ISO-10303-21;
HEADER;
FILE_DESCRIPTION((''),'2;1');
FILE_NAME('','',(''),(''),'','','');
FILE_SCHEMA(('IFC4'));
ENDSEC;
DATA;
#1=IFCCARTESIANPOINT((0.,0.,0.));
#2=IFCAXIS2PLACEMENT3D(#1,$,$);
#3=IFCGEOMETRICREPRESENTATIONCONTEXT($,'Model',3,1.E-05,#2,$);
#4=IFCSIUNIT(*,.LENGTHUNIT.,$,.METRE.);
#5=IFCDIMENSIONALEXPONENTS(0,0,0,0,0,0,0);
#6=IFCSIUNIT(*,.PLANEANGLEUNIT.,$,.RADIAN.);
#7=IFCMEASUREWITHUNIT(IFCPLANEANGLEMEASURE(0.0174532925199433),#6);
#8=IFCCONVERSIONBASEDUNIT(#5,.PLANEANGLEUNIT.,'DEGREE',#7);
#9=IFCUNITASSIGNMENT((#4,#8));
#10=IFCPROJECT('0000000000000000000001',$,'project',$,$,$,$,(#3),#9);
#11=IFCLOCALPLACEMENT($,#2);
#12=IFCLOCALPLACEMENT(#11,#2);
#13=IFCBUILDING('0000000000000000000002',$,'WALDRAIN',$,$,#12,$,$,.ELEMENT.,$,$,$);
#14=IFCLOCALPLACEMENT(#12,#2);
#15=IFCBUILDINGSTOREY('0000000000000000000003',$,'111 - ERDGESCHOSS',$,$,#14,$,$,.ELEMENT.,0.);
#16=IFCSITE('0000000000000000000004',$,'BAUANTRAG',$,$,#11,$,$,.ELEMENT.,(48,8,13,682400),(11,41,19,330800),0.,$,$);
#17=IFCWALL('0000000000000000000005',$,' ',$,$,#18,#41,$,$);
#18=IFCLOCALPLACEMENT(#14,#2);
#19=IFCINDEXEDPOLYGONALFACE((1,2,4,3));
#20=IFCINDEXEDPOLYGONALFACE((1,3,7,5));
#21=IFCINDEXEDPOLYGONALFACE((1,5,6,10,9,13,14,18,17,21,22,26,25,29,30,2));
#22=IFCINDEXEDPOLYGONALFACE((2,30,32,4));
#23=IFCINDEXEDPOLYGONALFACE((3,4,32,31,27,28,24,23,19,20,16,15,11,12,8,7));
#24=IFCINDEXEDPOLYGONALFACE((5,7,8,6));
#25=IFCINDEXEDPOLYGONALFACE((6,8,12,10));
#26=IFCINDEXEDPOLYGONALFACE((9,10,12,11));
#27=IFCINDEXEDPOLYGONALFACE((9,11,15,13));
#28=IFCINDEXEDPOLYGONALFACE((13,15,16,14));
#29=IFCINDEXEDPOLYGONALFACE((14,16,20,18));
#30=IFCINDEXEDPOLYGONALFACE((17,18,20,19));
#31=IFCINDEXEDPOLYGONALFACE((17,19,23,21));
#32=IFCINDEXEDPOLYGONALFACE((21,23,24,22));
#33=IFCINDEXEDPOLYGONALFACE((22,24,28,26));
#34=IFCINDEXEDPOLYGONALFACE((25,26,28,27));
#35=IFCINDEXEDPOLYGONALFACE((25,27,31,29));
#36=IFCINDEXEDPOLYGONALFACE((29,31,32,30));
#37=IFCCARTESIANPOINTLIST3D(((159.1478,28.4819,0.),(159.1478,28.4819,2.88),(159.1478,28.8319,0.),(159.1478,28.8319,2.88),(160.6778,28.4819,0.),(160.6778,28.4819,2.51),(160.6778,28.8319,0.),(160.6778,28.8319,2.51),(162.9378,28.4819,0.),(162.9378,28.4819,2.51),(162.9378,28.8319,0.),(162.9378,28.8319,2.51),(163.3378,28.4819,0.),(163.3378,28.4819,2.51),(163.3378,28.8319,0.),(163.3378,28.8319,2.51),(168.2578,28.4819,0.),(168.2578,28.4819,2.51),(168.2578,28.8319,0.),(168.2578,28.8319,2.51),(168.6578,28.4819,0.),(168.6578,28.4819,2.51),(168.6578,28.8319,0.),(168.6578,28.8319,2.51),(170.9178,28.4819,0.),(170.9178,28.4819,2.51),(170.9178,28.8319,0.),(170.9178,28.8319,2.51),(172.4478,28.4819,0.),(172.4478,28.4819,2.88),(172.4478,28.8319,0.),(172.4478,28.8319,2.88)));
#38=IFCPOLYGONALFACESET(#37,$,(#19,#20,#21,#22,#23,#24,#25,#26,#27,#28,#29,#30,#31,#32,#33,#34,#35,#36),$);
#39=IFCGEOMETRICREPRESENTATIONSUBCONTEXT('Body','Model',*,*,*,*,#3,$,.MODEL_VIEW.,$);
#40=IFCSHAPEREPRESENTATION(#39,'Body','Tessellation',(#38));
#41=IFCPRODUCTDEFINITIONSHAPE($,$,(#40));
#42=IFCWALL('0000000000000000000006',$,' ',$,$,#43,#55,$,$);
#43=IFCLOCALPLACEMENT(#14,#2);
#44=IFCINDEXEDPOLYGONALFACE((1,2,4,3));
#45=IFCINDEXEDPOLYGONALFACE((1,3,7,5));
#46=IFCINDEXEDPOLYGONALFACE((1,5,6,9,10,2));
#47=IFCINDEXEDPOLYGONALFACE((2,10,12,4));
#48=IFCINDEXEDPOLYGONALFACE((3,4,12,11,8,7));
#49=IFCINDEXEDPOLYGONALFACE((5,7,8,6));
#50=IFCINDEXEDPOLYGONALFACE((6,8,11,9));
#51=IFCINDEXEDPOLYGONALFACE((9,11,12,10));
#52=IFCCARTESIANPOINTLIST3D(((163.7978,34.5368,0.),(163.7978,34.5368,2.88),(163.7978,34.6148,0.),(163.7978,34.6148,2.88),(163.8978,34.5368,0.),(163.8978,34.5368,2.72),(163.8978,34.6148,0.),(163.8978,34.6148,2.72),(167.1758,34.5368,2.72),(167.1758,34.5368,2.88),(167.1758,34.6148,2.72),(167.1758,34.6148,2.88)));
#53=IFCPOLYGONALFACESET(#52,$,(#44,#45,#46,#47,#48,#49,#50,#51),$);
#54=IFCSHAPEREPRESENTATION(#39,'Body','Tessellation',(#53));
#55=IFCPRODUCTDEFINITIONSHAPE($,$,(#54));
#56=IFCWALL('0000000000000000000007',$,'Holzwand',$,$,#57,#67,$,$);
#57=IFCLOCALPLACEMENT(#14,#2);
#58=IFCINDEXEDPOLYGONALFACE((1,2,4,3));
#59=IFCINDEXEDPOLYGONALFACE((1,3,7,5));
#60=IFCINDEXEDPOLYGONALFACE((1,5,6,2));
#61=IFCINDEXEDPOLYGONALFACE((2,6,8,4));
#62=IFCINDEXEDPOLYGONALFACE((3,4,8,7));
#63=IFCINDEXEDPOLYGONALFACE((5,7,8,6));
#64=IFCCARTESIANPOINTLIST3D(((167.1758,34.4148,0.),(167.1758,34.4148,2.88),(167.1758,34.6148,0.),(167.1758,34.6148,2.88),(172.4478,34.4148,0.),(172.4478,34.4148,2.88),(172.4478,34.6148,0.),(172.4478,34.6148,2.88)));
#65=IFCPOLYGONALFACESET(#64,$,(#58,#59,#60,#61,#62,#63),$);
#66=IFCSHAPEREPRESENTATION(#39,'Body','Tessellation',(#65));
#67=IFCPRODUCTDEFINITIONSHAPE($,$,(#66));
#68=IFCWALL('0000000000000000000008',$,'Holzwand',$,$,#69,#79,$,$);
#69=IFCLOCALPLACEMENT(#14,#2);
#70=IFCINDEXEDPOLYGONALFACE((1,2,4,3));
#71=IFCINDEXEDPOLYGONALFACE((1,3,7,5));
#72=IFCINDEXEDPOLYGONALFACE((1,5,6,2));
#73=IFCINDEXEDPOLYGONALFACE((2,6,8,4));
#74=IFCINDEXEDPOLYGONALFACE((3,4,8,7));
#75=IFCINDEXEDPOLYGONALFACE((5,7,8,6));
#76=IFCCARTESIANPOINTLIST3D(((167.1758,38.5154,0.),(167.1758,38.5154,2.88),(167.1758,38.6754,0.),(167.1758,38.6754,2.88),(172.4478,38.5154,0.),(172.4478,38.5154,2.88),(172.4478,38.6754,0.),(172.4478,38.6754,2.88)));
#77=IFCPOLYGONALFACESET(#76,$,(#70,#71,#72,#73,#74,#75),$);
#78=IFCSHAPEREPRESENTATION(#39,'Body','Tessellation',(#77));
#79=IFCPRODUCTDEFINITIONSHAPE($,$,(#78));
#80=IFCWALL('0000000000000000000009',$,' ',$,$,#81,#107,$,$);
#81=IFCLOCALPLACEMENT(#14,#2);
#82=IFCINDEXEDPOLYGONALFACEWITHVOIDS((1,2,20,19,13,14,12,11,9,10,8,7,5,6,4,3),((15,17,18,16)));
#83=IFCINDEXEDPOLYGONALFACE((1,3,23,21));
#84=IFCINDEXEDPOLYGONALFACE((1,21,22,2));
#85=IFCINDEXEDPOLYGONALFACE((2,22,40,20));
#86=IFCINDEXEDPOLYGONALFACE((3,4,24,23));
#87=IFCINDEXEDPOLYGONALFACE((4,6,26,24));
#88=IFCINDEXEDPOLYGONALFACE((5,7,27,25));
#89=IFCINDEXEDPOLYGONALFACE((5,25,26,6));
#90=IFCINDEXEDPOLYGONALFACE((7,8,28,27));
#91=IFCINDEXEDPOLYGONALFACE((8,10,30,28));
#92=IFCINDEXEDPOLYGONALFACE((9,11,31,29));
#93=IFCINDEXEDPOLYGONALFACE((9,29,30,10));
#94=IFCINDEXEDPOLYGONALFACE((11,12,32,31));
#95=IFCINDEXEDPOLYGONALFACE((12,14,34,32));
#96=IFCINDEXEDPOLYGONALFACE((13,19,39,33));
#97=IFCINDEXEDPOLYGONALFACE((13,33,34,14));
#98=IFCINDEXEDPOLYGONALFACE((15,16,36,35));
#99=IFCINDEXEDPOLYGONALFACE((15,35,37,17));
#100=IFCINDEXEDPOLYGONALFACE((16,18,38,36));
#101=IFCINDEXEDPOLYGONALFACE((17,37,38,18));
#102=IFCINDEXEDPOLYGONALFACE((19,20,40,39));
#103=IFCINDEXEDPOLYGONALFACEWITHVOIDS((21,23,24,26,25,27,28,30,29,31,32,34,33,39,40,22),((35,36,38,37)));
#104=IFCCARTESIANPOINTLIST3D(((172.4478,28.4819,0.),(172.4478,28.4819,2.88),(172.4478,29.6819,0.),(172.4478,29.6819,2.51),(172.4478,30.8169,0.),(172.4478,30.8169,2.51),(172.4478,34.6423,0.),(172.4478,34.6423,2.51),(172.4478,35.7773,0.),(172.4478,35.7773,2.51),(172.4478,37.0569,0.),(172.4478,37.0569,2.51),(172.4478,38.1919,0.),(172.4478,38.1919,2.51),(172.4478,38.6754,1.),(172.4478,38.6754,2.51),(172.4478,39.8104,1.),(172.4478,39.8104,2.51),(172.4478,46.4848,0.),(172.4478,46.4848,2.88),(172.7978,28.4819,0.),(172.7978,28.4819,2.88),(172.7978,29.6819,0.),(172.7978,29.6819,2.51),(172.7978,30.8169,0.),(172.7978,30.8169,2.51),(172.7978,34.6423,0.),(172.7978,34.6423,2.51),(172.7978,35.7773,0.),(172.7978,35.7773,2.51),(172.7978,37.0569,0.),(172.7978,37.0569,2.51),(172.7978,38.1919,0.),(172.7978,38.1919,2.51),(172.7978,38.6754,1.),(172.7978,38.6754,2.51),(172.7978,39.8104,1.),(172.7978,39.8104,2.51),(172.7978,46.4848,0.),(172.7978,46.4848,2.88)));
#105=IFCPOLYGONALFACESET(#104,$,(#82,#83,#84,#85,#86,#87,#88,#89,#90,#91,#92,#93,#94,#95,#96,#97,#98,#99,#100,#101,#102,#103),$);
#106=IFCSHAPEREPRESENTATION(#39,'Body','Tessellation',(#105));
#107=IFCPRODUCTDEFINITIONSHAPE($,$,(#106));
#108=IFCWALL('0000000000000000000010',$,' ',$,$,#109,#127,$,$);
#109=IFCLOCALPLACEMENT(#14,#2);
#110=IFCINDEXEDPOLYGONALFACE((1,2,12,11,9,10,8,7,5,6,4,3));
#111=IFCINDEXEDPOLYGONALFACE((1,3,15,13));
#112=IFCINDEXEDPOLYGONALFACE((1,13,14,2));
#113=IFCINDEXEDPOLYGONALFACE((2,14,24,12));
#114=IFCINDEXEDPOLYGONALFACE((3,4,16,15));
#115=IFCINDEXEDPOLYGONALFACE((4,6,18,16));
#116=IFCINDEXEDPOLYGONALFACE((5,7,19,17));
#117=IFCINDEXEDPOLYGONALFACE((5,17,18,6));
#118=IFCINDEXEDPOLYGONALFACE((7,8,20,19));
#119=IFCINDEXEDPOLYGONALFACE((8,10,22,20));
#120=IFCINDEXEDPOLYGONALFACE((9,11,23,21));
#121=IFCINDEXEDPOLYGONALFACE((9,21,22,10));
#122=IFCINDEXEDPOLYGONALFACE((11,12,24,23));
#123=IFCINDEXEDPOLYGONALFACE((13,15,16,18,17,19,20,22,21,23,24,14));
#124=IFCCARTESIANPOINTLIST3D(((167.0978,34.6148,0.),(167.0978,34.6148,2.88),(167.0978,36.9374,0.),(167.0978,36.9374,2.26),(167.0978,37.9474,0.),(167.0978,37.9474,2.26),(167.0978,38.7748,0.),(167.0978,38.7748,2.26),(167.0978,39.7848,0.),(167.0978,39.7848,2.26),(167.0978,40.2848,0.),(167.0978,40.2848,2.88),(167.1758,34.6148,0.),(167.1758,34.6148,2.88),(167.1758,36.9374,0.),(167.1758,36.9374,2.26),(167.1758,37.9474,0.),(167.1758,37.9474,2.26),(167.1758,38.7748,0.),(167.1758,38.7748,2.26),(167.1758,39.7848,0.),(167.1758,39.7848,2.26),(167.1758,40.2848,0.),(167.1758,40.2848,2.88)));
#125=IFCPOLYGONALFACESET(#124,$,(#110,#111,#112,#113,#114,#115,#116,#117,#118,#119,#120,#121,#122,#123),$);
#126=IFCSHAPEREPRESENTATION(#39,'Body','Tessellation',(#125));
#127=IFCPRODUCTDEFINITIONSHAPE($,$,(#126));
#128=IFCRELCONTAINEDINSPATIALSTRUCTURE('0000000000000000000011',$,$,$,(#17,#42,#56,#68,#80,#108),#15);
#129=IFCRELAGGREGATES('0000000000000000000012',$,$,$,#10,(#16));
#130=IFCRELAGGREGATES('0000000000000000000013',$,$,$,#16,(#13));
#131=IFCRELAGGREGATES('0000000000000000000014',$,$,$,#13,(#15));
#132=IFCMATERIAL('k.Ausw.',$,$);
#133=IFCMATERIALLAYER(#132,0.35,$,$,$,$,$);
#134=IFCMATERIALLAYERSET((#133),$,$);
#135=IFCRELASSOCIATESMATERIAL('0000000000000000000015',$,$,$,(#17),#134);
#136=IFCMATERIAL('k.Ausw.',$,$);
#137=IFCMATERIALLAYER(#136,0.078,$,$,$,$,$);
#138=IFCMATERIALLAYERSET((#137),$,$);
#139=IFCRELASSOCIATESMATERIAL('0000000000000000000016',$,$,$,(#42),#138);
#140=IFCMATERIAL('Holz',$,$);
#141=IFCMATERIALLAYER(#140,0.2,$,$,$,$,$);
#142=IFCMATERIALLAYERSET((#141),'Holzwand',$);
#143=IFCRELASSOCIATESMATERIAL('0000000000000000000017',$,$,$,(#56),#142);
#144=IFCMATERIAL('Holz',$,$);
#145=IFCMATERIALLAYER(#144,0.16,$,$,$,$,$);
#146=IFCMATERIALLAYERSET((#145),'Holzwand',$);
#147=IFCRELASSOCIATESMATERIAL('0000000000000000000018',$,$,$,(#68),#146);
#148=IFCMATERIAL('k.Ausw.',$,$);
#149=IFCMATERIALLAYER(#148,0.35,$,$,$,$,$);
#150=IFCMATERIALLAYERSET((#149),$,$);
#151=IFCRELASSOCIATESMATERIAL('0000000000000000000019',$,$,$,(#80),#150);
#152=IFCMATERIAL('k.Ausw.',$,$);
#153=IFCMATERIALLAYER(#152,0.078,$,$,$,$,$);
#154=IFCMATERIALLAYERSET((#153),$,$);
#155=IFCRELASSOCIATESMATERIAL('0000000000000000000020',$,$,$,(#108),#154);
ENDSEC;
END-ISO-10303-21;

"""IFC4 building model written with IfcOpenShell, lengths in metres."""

from ifc_helpers import new_model, entity, si_unit, converted_unit, frame, frame_2d, origin, origin_with_axes, place, context, subcontext, project, spatial, polyline, rectangle, outline, extrude, material, layer, layer_set, layer_usage, element, save


model = new_model("IFC4")

# Units and contexts
model_context = context("Model", 3, precision=1e-05, world=origin())
body_context = subcontext(model_context, "Body", "Model", "MODEL_VIEW")
ifc_project = project(units=[si_unit("LENGTHUNIT", "METRE"), converted_unit("PLANEANGLEUNIT", "DEGREE", entity("IfcPlaneAngleMeasure", 0.0174532925199433), si_unit("PLANEANGLEUNIT", "RADIAN"), dimensions=[0, 0, 0, 0, 0, 0, 0])], contexts=[model_context])

# Site, building, storey
site_placement = place(None, origin())
site = spatial("IfcSite", under=ifc_project, at=site_placement, Name="BAUANTRAG", CompositionType="ELEMENT", RefLatitude=(48, 8, 13, 682400), RefLongitude=(11, 41, 19, 330800), RefElevation=0.0)
building_placement = place(site_placement, origin())
building = spatial("IfcBuilding", under=site, at=building_placement, Name="WALDRAIN", CompositionType="ELEMENT")
storey_placement = place(building_placement, origin())
storey = spatial("IfcBuildingStorey", under=building, at=storey_placement, Name="111 - ERDGESCHOSS", CompositionType="ELEMENT", Elevation=0.0)

# Wall, openings
ifc_material_1 = material(Name="k.Ausw.")
ifc_layer_1 = layer(ifc_material_1, 0.35)
ifc_layer_set_1 = layer_set([ifc_layer_1])
ifc_layer_usage_1 = layer_usage(ifc_layer_set_1, "AXIS2", "POSITIVE", 0.0)
wall_1_placement = place(storey_placement, frame((159.1478, 28.4819, 0.0)))
wall_1 = element("IfcWall", 1, at=wall_1_placement, inside=storey, material=ifc_layer_usage_1, Name=" ", context=body_context, shape_type="SweptSolid", body=[
    extrude(rectangle(XDim=13.3, YDim=0.35, at=frame_2d((6.65, 0.175), x_axis=(1.0, 0.0))), origin_with_axes(), (0.0, 0.0, 1.0), 2.88),
])
opening_1_placement = place(wall_1_placement, frame((1.53, 0.0, 0.0), z_axis=(0.0, 1.0, 0.0), x_axis=(0.0, 0.0, 1.0)))
element("IfcOpeningElement", 2, at=opening_1_placement, cuts=wall_1, ObjectType="Opening", context=body_context, shape_type="SweptSolid", body=[
    extrude(outline(polyline([(0.0, 2.26), (2.51, 2.26), (2.51, 0.0), (0.0, 0.0), (0.0, 2.26)])), origin_with_axes(), (0.0, 0.0, 1.0), 0.35),
])
opening_2_placement = place(wall_1_placement, frame((4.19, 0.0, 0.0), z_axis=(0.0, 1.0, 0.0), x_axis=(0.0, 0.0, 1.0)))
element("IfcOpeningElement", 3, at=opening_2_placement, cuts=wall_1, ObjectType="Opening", context=body_context, shape_type="SweptSolid", body=[
    extrude(outline(polyline([(0.0, 4.92), (2.51, 4.92), (2.51, 0.0), (0.0, 0.0), (0.0, 4.92)])), origin_with_axes(), (0.0, 0.0, 1.0), 0.35),
])
opening_3_placement = place(wall_1_placement, frame((9.51, 0.0, 0.0), z_axis=(0.0, 1.0, 0.0), x_axis=(0.0, 0.0, 1.0)))
element("IfcOpeningElement", 4, at=opening_3_placement, cuts=wall_1, ObjectType="Opening", context=body_context, shape_type="SweptSolid", body=[
    extrude(outline(polyline([(0.0, 2.26), (2.51, 2.26), (2.51, 0.0), (0.0, 0.0), (0.0, 2.26)])), origin_with_axes(), (0.0, 0.0, 1.0), 0.35),
])

# Wall, opening
ifc_material_2 = material(Name="k.Ausw.")
ifc_layer_2 = layer(ifc_material_2, 0.078)
ifc_layer_set_2 = layer_set([ifc_layer_2])
ifc_layer_usage_2 = layer_usage(ifc_layer_set_2, "AXIS2", "POSITIVE", 0.0)
wall_2_placement = place(storey_placement, frame((163.7978, 34.5368, 0.0)))
wall_2 = element("IfcWall", 5, at=wall_2_placement, inside=storey, material=ifc_layer_usage_2, Name=" ", context=body_context, shape_type="SweptSolid", body=[
    extrude(rectangle(XDim=3.378, YDim=0.078, at=frame_2d((1.689, 0.039), x_axis=(1.0, 0.0))), origin_with_axes(), (0.0, 0.0, 1.0), 2.88),
])
opening_4_placement = place(wall_2_placement, frame((0.1, 0.0, 0.0), z_axis=(0.0, 1.0, 0.0), x_axis=(0.0, 0.0, 1.0)))
element("IfcOpeningElement", 6, at=opening_4_placement, cuts=wall_2, ObjectType="Opening", context=body_context, shape_type="SweptSolid", body=[
    extrude(outline(polyline([(0.0, 3.278), (2.72, 3.278), (2.72, 0.0), (0.0, 0.0), (0.0, 3.278)])), origin_with_axes(), (0.0, 0.0, 1.0), 0.078),
])

# Walls
ifc_material_3 = material(Name="Holz")
ifc_layer_3 = layer(ifc_material_3, 0.2)
ifc_layer_set_3 = layer_set([ifc_layer_3], Name="Holzwand")
ifc_layer_usage_3 = layer_usage(ifc_layer_set_3, "AXIS2", "POSITIVE", 0.0)
wall_3_placement = place(storey_placement, frame((167.1758, 34.4148, 0.0)))
element("IfcWall", 7, at=wall_3_placement, inside=storey, material=ifc_layer_usage_3, Name="Holzwand", context=body_context, shape_type="SweptSolid", body=[
    extrude(rectangle(XDim=5.272, YDim=0.2, at=frame_2d((2.636, 0.1), x_axis=(1.0, 0.0))), origin_with_axes(), (0.0, 0.0, 1.0), 2.88),
])
ifc_material_4 = material(Name="Holz")
ifc_layer_4 = layer(ifc_material_4, 0.16)
ifc_layer_set_4 = layer_set([ifc_layer_4], Name="Holzwand")
ifc_layer_usage_4 = layer_usage(ifc_layer_set_4, "AXIS2", "POSITIVE", 0.0)
wall_4_placement = place(storey_placement, frame((172.4478, 38.6754, 0.0), z_axis=(0.0, 0.0, 1.0), x_axis=(-1.0, 0.0, 0.0)))
element("IfcWall", 8, at=wall_4_placement, inside=storey, material=ifc_layer_usage_4, Name="Holzwand", context=body_context, shape_type="SweptSolid", body=[
    extrude(rectangle(XDim=5.272, YDim=0.16, at=frame_2d((2.636, 0.08), x_axis=(1.0, 0.0))), origin_with_axes(), (0.0, 0.0, 1.0), 2.88),
])

# Walls, openings
ifc_material_5 = material(Name="k.Ausw.")
ifc_layer_5 = layer(ifc_material_5, 0.35)
ifc_layer_set_5 = layer_set([ifc_layer_5])
ifc_layer_usage_5 = layer_usage(ifc_layer_set_5, "AXIS2", "POSITIVE", 0.0)
wall_5_placement = place(storey_placement, frame((172.7978, 28.4819, 0.0), z_axis=(0.0, 0.0, 1.0), x_axis=(0.0, 1.0, 0.0)))
wall_5 = element("IfcWall", 9, at=wall_5_placement, inside=storey, material=ifc_layer_usage_5, Name=" ", context=body_context, shape_type="SweptSolid", body=[
    extrude(rectangle(XDim=18.0029, YDim=0.35, at=frame_2d((9.0014, 0.175), x_axis=(1.0, 0.0))), origin_with_axes(), (0.0, 0.0, 1.0), 2.88),
])
opening_5_placement = place(wall_5_placement, frame((1.2, 0.0, 0.0), z_axis=(0.0, 1.0, 0.0), x_axis=(0.0, 0.0, 1.0)))
element("IfcOpeningElement", 10, at=opening_5_placement, cuts=wall_5, ObjectType="Opening", context=body_context, shape_type="SweptSolid", body=[
    extrude(outline(polyline([(0.0, 1.135), (2.51, 1.135), (2.51, 0.0), (0.0, 0.0), (0.0, 1.135)])), origin_with_axes(), (0.0, 0.0, 1.0), 0.35),
])
opening_6_placement = place(wall_5_placement, frame((6.1604, 0.0, 0.0), z_axis=(0.0, 1.0, 0.0), x_axis=(0.0, 0.0, 1.0)))
element("IfcOpeningElement", 11, at=opening_6_placement, cuts=wall_5, ObjectType="Opening", context=body_context, shape_type="SweptSolid", body=[
    extrude(outline(polyline([(0.0, 1.135), (2.51, 1.135), (2.51, 0.0), (0.0, 0.0), (0.0, 1.135)])), origin_with_axes(), (0.0, 0.0, 1.0), 0.35),
])
opening_7_placement = place(wall_5_placement, frame((8.575, 0.0, 0.0), z_axis=(0.0, 1.0, 0.0), x_axis=(0.0, 0.0, 1.0)))
element("IfcOpeningElement", 12, at=opening_7_placement, cuts=wall_5, ObjectType="Opening", context=body_context, shape_type="SweptSolid", body=[
    extrude(outline(polyline([(0.0, 1.135), (2.51, 1.135), (2.51, 0.0), (0.0, 0.0), (0.0, 1.135)])), origin_with_axes(), (0.0, 0.0, 1.0), 0.35),
])
opening_8_placement = place(wall_5_placement, frame((10.1935, 0.0, 1.0), z_axis=(0.0, 1.0, 0.0), x_axis=(0.0, 0.0, 1.0)))
element("IfcOpeningElement", 13, at=opening_8_placement, cuts=wall_5, ObjectType="Opening", context=body_context, shape_type="SweptSolid", body=[
    extrude(outline(polyline([(0.0, 1.135), (1.51, 1.135), (1.51, 0.0), (0.0, 0.0), (0.0, 1.135)])), origin_with_axes(), (0.0, 0.0, 1.0), 0.35),
])
ifc_material_6 = material(Name="k.Ausw.")
ifc_layer_6 = layer(ifc_material_6, 0.078)
ifc_layer_set_6 = layer_set([ifc_layer_6])
ifc_layer_usage_6 = layer_usage(ifc_layer_set_6, "AXIS2", "POSITIVE", 0.0)
wall_6_placement = place(storey_placement, frame((167.1758, 34.6148, 0.0), z_axis=(0.0, 0.0, 1.0), x_axis=(0.0, 1.0, 0.0)))
wall_6 = element("IfcWall", 14, at=wall_6_placement, inside=storey, material=ifc_layer_usage_6, Name=" ", context=body_context, shape_type="SweptSolid", body=[
    extrude(rectangle(XDim=5.67, YDim=0.078, at=frame_2d((2.835, 0.039), x_axis=(1.0, 0.0))), origin_with_axes(), (0.0, 0.0, 1.0), 2.88),
])
opening_9_placement = place(wall_6_placement, frame((4.16, 0.0, 0.0), z_axis=(0.0, 1.0, 0.0), x_axis=(0.0, 0.0, 1.0)))
element("IfcOpeningElement", 15, at=opening_9_placement, cuts=wall_6, ObjectType="Opening", context=body_context, shape_type="SweptSolid", body=[
    extrude(outline(polyline([(0.0, 1.01), (2.26, 1.01), (2.26, 0.0), (0.0, 0.0), (0.0, 1.01)])), origin_with_axes(), (0.0, 0.0, 1.0), 0.078),
])
opening_10_placement = place(wall_6_placement, frame((2.3226, 0.0, 0.0), z_axis=(0.0, 1.0, 0.0), x_axis=(0.0, 0.0, 1.0)))
element("IfcOpeningElement", 16, at=opening_10_placement, cuts=wall_6, ObjectType="Opening", context=body_context, shape_type="SweptSolid", body=[
    extrude(outline(polyline([(0.0, 1.01), (2.26, 1.01), (2.26, 0.0), (0.0, 0.0), (0.0, 1.01)])), origin_with_axes(), (0.0, 0.0, 1.0), 0.078),
])

save(model, "model.ifc")
